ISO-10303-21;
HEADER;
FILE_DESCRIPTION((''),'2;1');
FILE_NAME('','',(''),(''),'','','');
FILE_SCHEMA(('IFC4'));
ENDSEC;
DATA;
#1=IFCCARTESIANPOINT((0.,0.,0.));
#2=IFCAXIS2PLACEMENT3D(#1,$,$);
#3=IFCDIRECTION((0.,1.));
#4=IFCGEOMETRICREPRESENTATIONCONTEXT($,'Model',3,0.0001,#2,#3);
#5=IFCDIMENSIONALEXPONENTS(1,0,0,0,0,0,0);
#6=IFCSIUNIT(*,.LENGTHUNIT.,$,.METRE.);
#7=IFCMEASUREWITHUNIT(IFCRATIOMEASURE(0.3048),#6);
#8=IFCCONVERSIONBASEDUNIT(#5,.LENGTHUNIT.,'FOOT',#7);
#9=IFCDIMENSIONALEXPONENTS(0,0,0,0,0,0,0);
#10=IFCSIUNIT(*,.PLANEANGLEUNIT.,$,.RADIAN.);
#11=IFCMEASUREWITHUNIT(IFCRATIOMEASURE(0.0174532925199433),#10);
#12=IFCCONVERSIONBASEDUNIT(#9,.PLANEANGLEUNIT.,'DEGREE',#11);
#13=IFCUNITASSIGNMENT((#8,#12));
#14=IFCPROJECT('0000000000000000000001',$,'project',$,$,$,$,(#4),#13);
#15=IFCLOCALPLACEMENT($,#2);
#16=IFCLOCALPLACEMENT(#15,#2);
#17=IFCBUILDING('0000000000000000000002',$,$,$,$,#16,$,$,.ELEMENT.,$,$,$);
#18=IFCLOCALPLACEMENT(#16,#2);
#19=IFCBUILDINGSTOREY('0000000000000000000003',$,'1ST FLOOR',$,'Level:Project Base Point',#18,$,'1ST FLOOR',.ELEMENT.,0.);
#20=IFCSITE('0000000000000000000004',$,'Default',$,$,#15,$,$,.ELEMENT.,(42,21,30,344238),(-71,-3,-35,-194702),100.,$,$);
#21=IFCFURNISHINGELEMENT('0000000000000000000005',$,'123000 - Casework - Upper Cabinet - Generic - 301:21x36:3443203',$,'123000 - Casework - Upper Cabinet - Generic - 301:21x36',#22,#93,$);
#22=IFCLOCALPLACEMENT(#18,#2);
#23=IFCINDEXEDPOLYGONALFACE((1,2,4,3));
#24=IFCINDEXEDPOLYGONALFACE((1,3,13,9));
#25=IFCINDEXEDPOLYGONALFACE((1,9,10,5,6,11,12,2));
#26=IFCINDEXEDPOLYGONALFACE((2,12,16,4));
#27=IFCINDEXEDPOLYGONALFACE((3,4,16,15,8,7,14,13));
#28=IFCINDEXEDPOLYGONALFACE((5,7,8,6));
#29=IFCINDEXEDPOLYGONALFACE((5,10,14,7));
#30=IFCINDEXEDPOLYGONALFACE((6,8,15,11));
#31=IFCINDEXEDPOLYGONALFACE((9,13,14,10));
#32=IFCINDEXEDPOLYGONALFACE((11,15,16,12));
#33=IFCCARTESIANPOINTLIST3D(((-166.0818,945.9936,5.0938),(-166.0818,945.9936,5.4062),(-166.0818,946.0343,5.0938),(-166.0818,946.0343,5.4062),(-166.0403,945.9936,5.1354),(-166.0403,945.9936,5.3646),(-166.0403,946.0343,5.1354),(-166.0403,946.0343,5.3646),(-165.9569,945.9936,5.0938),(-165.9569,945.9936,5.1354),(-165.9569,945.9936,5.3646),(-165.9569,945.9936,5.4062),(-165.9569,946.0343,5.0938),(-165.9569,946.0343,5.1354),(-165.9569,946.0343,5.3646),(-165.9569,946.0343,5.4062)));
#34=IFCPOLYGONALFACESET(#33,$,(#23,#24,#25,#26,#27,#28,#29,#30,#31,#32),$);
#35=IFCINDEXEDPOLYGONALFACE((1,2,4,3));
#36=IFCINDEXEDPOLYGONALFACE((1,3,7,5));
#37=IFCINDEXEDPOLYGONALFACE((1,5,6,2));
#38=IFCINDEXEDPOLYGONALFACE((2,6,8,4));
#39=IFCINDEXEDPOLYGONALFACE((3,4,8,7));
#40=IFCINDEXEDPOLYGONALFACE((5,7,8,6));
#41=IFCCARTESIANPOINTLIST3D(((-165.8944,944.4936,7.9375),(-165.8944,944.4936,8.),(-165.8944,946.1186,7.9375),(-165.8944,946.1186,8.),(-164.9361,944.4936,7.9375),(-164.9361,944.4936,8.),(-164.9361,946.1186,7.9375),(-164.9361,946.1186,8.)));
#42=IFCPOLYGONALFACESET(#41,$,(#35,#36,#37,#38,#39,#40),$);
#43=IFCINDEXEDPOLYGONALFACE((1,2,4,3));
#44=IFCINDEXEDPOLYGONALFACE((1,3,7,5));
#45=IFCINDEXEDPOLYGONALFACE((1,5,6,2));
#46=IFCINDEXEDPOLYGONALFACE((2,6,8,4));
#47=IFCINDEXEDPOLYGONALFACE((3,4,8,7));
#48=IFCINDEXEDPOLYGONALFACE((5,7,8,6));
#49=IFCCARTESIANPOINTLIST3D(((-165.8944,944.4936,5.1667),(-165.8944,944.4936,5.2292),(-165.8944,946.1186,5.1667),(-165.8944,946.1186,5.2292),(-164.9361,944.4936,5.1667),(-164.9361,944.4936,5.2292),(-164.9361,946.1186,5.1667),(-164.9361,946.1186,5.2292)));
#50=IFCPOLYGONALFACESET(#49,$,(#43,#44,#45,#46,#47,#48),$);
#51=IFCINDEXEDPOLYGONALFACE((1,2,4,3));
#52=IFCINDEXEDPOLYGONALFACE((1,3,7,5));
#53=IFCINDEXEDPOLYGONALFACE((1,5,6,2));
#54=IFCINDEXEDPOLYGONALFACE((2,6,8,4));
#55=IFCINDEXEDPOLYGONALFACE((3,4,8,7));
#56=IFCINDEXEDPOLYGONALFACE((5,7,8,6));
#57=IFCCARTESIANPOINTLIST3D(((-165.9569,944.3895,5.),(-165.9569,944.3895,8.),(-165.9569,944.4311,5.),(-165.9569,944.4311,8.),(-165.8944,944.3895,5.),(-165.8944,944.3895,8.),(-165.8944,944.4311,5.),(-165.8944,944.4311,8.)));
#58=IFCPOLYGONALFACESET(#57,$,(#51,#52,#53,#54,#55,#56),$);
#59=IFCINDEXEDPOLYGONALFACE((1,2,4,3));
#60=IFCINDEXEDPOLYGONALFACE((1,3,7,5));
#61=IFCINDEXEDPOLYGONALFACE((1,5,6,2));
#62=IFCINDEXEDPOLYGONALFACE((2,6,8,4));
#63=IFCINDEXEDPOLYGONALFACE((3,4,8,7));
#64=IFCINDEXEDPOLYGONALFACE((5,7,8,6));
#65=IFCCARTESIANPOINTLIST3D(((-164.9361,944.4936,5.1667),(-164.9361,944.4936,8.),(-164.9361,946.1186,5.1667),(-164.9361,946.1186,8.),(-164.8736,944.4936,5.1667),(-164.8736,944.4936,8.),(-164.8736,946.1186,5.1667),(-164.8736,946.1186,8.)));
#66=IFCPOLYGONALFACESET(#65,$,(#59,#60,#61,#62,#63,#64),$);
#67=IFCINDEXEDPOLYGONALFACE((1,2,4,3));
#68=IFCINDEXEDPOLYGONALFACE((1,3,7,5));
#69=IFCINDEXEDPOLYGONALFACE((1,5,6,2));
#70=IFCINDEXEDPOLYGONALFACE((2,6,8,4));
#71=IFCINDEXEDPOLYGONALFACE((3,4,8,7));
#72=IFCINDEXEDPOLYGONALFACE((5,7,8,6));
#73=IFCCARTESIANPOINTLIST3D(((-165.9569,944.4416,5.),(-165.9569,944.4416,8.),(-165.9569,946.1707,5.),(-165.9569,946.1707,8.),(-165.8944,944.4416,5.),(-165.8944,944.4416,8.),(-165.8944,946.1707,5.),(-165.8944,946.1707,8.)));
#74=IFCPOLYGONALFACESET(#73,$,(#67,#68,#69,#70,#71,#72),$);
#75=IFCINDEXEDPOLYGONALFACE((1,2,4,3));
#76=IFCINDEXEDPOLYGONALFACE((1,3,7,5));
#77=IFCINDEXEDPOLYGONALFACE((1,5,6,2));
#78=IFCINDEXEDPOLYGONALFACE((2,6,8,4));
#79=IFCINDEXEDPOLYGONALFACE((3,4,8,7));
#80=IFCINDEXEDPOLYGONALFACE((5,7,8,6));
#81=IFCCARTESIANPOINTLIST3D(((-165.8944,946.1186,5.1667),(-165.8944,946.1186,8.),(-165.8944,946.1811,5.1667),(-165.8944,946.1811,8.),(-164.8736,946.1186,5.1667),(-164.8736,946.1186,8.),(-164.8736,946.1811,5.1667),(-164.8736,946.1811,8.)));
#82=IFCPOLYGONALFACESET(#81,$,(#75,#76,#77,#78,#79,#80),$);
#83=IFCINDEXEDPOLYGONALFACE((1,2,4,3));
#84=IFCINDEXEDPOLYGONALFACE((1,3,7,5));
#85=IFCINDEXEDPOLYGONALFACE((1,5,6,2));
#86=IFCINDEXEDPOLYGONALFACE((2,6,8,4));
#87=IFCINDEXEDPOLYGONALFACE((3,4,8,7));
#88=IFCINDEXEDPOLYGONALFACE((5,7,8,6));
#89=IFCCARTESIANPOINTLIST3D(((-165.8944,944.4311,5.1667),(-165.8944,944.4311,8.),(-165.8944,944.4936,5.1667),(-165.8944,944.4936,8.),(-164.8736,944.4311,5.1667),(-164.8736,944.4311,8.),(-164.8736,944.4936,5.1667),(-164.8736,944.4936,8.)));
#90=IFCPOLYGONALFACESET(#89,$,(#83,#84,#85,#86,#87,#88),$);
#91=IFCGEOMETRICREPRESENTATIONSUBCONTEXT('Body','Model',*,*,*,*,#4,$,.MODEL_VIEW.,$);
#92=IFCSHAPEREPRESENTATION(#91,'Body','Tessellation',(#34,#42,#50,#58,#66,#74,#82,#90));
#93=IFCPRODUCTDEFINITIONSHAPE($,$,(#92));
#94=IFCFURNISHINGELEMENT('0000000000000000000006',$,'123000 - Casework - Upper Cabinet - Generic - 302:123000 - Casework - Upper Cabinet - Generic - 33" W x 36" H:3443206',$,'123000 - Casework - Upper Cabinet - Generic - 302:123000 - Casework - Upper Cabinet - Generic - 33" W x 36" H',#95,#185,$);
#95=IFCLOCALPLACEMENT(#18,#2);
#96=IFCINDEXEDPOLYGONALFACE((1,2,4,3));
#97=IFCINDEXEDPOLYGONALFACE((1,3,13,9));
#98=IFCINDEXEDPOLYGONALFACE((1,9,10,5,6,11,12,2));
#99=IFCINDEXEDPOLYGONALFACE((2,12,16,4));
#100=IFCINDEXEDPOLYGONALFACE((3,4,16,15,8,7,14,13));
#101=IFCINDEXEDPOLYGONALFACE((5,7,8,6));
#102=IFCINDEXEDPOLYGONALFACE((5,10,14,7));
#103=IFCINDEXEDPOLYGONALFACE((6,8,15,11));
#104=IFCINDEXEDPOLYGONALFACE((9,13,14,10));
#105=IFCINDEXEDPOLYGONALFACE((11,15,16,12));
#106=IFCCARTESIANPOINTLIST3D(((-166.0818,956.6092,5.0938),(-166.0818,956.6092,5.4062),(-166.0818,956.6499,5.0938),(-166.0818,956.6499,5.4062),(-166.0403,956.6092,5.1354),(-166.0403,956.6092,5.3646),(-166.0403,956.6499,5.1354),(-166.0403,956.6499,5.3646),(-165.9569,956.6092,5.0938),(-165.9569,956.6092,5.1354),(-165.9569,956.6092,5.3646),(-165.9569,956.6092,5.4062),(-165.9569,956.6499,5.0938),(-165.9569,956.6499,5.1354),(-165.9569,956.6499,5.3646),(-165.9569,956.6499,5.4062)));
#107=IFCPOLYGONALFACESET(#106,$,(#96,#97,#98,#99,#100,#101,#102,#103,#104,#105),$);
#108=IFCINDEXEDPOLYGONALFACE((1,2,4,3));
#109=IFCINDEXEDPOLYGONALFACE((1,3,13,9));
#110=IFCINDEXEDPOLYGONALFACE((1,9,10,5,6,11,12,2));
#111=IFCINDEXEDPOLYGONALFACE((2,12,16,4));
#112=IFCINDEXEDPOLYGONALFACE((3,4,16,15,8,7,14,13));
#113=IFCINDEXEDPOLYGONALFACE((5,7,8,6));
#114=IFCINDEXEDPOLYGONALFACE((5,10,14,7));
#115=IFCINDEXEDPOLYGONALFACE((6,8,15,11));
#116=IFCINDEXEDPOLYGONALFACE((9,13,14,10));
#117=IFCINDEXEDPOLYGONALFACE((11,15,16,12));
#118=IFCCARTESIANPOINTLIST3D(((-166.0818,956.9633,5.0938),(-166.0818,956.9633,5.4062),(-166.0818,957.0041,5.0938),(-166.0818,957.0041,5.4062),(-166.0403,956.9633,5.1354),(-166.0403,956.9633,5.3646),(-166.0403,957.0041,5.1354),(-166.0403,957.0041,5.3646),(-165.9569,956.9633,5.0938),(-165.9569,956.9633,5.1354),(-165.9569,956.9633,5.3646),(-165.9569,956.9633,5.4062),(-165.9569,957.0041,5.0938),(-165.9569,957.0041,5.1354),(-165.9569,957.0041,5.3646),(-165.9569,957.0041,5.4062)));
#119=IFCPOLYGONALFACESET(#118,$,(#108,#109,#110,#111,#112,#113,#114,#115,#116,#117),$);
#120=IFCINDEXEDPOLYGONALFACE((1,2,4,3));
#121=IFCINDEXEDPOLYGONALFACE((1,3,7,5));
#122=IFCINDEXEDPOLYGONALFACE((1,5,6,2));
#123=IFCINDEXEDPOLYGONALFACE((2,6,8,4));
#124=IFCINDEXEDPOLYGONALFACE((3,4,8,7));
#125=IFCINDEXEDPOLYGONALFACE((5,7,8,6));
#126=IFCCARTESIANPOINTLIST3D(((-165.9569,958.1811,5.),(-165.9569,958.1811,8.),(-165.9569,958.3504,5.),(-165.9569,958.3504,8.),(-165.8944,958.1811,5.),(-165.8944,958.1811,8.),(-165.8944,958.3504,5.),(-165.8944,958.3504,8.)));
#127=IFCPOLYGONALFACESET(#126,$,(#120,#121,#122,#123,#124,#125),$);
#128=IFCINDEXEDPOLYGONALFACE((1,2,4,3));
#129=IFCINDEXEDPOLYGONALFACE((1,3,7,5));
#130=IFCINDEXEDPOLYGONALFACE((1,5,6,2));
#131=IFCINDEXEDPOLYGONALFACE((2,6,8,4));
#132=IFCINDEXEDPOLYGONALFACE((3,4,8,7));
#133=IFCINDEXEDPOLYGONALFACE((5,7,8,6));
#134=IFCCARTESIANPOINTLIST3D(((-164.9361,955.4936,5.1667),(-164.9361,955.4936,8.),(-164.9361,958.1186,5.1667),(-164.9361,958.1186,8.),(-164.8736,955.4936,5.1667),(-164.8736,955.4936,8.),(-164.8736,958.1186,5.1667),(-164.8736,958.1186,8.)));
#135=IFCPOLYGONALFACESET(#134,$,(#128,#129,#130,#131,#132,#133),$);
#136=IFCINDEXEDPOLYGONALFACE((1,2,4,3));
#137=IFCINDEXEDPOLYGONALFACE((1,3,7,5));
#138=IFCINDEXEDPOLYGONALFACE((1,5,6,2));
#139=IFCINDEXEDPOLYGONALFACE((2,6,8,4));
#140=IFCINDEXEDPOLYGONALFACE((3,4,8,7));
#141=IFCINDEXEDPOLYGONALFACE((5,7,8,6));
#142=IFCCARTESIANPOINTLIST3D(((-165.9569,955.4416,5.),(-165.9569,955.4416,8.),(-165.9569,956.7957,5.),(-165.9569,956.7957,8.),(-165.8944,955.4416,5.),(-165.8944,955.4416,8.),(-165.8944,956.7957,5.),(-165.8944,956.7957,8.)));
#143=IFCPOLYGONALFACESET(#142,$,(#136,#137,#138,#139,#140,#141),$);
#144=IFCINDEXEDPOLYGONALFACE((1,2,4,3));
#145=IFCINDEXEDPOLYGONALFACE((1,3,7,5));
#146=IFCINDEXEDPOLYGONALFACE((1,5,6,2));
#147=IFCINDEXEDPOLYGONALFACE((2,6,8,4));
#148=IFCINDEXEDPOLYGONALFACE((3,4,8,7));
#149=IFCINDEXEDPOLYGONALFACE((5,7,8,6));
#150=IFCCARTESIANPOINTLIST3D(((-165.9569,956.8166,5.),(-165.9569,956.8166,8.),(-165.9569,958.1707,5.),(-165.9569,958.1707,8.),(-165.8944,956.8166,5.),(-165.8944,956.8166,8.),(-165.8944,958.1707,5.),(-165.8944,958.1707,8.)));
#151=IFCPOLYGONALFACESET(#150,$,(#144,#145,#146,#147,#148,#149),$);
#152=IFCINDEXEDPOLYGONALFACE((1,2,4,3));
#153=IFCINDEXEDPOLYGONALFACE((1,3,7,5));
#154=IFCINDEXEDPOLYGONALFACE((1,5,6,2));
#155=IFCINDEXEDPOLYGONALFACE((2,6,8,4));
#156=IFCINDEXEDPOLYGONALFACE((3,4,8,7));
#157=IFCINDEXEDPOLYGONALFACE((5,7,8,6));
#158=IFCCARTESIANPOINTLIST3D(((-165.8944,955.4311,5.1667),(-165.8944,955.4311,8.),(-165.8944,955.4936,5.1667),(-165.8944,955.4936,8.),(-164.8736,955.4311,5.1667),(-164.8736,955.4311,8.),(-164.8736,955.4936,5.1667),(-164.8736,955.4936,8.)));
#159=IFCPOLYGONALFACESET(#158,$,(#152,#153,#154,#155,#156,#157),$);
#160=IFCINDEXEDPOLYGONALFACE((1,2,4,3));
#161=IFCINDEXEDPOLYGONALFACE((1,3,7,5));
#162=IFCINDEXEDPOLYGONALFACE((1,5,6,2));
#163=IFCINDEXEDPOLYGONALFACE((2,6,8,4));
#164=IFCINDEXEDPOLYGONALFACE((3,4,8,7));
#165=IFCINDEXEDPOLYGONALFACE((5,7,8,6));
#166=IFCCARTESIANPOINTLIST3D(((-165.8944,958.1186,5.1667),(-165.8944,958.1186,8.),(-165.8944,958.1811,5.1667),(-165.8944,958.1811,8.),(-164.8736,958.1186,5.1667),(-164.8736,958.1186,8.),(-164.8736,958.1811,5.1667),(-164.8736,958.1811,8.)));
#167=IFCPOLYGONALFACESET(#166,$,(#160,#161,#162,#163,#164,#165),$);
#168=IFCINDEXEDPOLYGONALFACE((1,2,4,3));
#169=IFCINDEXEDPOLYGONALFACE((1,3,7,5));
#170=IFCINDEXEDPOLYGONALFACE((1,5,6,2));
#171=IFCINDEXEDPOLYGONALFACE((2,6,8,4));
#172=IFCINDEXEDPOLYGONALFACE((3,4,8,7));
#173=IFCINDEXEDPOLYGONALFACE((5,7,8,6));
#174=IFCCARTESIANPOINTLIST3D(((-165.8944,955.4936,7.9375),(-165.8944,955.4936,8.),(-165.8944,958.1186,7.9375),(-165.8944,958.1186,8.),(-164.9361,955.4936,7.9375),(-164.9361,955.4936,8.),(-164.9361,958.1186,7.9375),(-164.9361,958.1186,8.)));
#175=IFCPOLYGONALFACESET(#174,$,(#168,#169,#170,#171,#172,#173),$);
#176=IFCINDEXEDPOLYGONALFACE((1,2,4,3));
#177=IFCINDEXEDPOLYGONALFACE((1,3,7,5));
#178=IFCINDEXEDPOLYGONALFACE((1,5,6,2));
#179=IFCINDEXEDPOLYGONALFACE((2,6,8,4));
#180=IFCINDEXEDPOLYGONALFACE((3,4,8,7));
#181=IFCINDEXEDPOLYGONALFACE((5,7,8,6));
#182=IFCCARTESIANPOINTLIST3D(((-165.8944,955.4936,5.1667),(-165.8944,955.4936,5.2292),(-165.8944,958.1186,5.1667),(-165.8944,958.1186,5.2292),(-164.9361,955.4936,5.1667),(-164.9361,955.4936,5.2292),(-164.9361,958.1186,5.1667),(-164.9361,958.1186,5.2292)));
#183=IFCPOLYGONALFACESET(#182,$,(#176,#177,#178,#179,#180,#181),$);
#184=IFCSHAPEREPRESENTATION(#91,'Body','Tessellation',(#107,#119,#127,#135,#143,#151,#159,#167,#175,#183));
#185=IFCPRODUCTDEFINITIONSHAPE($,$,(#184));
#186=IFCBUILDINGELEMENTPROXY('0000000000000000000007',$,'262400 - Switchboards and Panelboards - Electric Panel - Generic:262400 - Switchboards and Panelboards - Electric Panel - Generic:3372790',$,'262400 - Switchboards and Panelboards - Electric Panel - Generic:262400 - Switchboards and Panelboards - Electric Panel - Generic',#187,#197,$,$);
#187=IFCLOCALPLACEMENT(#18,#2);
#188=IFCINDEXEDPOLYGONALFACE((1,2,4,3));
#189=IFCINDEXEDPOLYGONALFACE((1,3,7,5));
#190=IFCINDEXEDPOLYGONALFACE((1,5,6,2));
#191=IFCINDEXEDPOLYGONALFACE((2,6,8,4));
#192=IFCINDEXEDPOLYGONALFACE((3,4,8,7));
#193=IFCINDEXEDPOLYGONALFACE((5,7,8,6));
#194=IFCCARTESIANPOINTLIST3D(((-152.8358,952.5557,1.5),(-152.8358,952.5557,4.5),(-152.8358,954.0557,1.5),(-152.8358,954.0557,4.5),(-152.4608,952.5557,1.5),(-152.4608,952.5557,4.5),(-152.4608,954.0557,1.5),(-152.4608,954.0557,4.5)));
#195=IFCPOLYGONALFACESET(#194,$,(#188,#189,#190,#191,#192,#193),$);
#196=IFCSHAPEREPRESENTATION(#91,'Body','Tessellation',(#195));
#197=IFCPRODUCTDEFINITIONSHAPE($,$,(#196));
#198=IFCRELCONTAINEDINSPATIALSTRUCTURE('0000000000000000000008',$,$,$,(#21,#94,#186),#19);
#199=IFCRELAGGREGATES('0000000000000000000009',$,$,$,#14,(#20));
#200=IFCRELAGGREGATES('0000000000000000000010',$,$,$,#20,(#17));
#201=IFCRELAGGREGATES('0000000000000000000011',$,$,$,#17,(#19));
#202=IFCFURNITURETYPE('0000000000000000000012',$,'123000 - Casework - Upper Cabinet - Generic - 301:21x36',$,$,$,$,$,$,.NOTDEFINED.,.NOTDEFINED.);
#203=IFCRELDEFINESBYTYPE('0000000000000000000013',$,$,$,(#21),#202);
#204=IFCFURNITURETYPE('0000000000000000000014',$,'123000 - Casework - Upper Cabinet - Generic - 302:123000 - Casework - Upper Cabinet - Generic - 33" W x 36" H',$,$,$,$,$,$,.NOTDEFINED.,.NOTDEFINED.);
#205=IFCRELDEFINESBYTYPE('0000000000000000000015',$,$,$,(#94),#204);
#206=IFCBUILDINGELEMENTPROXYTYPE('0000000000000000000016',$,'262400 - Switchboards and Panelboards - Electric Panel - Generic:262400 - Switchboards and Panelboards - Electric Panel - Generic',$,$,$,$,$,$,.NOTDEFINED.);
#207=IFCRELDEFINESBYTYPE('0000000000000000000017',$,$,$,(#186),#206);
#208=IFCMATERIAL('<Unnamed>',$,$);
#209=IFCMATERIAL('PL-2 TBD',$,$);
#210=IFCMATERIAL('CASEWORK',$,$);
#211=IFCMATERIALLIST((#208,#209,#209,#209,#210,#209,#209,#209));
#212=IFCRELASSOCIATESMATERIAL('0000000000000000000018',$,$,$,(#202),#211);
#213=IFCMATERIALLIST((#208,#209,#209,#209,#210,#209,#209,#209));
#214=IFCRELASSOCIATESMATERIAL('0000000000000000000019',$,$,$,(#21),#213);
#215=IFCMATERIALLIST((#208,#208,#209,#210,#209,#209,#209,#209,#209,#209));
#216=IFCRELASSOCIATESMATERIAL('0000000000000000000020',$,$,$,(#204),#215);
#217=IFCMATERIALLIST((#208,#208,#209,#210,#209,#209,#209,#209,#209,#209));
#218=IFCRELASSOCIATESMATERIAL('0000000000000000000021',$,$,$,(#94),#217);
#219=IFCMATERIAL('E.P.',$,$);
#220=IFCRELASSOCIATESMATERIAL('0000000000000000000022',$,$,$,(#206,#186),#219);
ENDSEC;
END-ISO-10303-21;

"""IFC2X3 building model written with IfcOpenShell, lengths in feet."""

from ifc_helpers import new_model, entity, si_unit, converted_unit, direction, frame, frame_2d, origin, origin_2d_with_axis, place, context, subcontext, project, spatial, polyline, rectangle, outline, extrude, source, transform, mapped, material, material_list, type_object, type_shapes, element, save


model = new_model("IFC2X3")

# Units and contexts
model_context = context("Model", 3, precision=0.0001, world=origin(), true_north=direction((0.0, 1.0)))
body_context = subcontext(model_context, "Body", "Model", "MODEL_VIEW")
ifc_project = project(units=[converted_unit("LENGTHUNIT", "FOOT", entity("IfcRatioMeasure", 0.3048), si_unit("LENGTHUNIT", "METRE"), dimensions=[1, 0, 0, 0, 0, 0, 0]), converted_unit("PLANEANGLEUNIT", "DEGREE", entity("IfcRatioMeasure", 0.0174532925199433), si_unit("PLANEANGLEUNIT", "RADIAN"), dimensions=[0, 0, 0, 0, 0, 0, 0])], contexts=[model_context])

# Site, building, storey
site_placement = place(None, origin())
site = spatial("IfcSite", under=ifc_project, at=site_placement, Name="Default", CompositionType="ELEMENT", RefLatitude=(42, 21, 30, 344238), RefLongitude=(-71, -3, -35, -194702), RefElevation=100.0)
building_placement = place(site_placement, origin())
building = spatial("IfcBuilding", under=site, at=building_placement, CompositionType="ELEMENT")
storey_placement = place(building_placement, origin())
storey = spatial("IfcBuildingStorey", under=building, at=storey_placement, Name="1ST FLOOR", ObjectType="Level:Project Base Point", LongName="1ST FLOOR", CompositionType="ELEMENT", Elevation=0.0)

# Shared definitions
ifc_material_1 = material(Name="CASEWORK")

# Furnishing elements
ifc_material_2 = material(Name="<Unnamed>")
ifc_material_3 = material(Name="PL-2 TBD")
ifc_material_list_1 = material_list([ifc_material_2, ifc_material_3, ifc_material_3, ifc_material_3, ifc_material_1, ifc_material_3, ifc_material_3, ifc_material_3])
ifc_material_list_2 = material_list([ifc_material_2, ifc_material_3, ifc_material_3, ifc_material_3, ifc_material_1, ifc_material_3, ifc_material_3, ifc_material_3])
furniture_type_1 = type_object("IfcFurnitureType", Name="123000 - Casework - Upper Cabinet - Generic - 301:21x36", material=ifc_material_list_2)
shared_shape_1 = source(origin(), body_context, "Body", "SweptSolid", [
    extrude(outline(polyline([(0.1146, -0.0521), (0.1562, -0.0521), (0.1562, 0.0729), (-0.1562, 0.0729), (-0.1562, -0.0521), (-0.1146, -0.0521), (-0.1146, 0.0313), (0.1146, 0.0313), (0.1146, -0.0521)])), frame((0.1468, 0.0729, 0.25), z_axis=(1.0, 0.0, 0.0), x_axis=(0.0, 0.0, 1.0)), (0.0, 0.0, 1.0), 0.0407),
    extrude(rectangle(XDim=1.625, YDim=0.9583, at=frame_2d((0.0, 0.0), x_axis=(1.0, 0.0))), frame((0.875, 0.6666, 2.9375), z_axis=(0.0, 0.0, 1.0), x_axis=(-1.0, 0.0, 0.0)), (0.0, 0.0, 1.0), 0.0625),
    extrude(rectangle(XDim=1.625, YDim=0.9583, at=frame_2d((0.0, 0.0), x_axis=(1.0, 0.0))), frame((0.875, 0.6666, 0.1667), z_axis=(0.0, 0.0, 1.0), x_axis=(-1.0, 0.0, 0.0)), (0.0, 0.0, 1.0), 0.0625),
    extrude(rectangle(XDim=0.0625, YDim=0.0417, at=frame_2d((0.0, 0.0), x_axis=(1.0, 0.0))), frame((1.7708, 0.1562, 0.0), z_axis=(0.0, 0.0, 1.0), x_axis=(0.0, -1.0, 0.0)), (0.0, 0.0, 1.0), 3.0),
    extrude(rectangle(XDim=0.0625, YDim=1.625, at=origin_2d_with_axis()), frame((0.875, 1.177, 0.1667), z_axis=(0.0, 0.0, 1.0), x_axis=(0.0, 1.0, 0.0)), (0.0, 0.0, 1.0), 2.8333),
    extrude(rectangle(XDim=0.0625, YDim=1.7292, at=frame_2d((0.0, 0.0), x_axis=(1.0, 0.0))), frame((0.875, 0.1562, 0.0), z_axis=(0.0, 0.0, 1.0), x_axis=(0.0, -1.0, 0.0)), (0.0, 0.0, 1.0), 3.0),
    extrude(rectangle(XDim=0.0625, YDim=1.0208, at=origin_2d_with_axis()), frame((0.0312, 0.6979, 0.1667), z_axis=(0.0, 0.0, 1.0), x_axis=(-1.0, 0.0, 0.0)), (0.0, 0.0, 1.0), 2.8333),
    extrude(rectangle(XDim=0.0625, YDim=1.0208, at=origin_2d_with_axis()), frame((1.7188, 0.6979, 0.1667), z_axis=(0.0, 0.0, 1.0), x_axis=(-1.0, 0.0, 0.0)), (0.0, 0.0, 1.0), 2.8333),
])
type_shapes(furniture_type_1, [shared_shape_1])
furnishing_1_placement = place(storey_placement, frame((-166.0818, 946.1811, 5.0), z_axis=(0.0, 0.0, 1.0), x_axis=(0.0, -1.0, 0.0)))
element("IfcFurnishingElement", 1, at=furnishing_1_placement, inside=storey, type_object=furniture_type_1, material=ifc_material_list_1, Name="123000 - Casework - Upper Cabinet - Generic - 301:21x36:3443203", ObjectType="123000 - Casework - Upper Cabinet - Generic - 301:21x36", context=body_context, shape_type="MappedRepresentation", body=[
    mapped(shared_shape_1, transform((0.0, 0.0, 0.0), scale=1.0)),
])
ifc_material_list_3 = material_list([ifc_material_2, ifc_material_2, ifc_material_3, ifc_material_1, ifc_material_3, ifc_material_3, ifc_material_3, ifc_material_3, ifc_material_3, ifc_material_3])
ifc_material_list_4 = material_list([ifc_material_2, ifc_material_2, ifc_material_3, ifc_material_1, ifc_material_3, ifc_material_3, ifc_material_3, ifc_material_3, ifc_material_3, ifc_material_3])
furniture_type_2 = type_object("IfcFurnitureType", Name="123000 - Casework - Upper Cabinet - Generic - 302:123000 - Casework - Upper Cabinet - Generic - 33\" W x 36\" H", material=ifc_material_list_4)
shared_shape_2 = source(origin(), body_context, "Body", "SweptSolid", [
    extrude(outline(polyline([(-0.0521, -0.1146), (-0.0521, -0.1562), (0.0729, -0.1562), (0.0729, 0.1562), (-0.0521, 0.1562), (-0.0521, 0.1146), (0.0313, 0.1146), (0.0313, -0.1146), (-0.0521, -0.1146)])), frame((1.178, 1.1354, 0.25), z_axis=(-1.0, 0.0, 0.0), x_axis=(0.0, 1.0, 0.0)), (0.0, 0.0, -1.0), 0.0407),
    extrude(outline(polyline([(-0.0521, -0.1146), (-0.0521, -0.1562), (0.0729, -0.1562), (0.0729, 0.1562), (-0.0521, 0.1562), (-0.0521, 0.1146), (0.0313, 0.1146), (0.0313, -0.1146), (-0.0521, -0.1146)])), frame((1.5322, 1.1354, 0.25), z_axis=(-1.0, 0.0, 0.0), x_axis=(0.0, 1.0, 0.0)), (0.0, 0.0, -1.0), 0.0407),
    extrude(rectangle(XDim=0.1693, YDim=0.0625, at=frame_2d((0.0, 0.0), x_axis=(1.0, 0.0))), frame((2.8346, 1.0521, 0.0)), (0.0, 0.0, 1.0), 3.0),
    extrude(rectangle(XDim=2.625, YDim=0.0625, at=frame_2d((0.0, 0.0), x_axis=(1.0, 0.0))), frame((1.375, 0.0313, 0.1667), z_axis=(0.0, 0.0, 1.0), x_axis=(-1.0, 0.0, 0.0)), (0.0, 0.0, 1.0), 2.8333),
    extrude(rectangle(XDim=1.3542, YDim=0.0625, at=origin_2d_with_axis()), frame((0.6875, 1.0521, 0.0)), (0.0, 0.0, 1.0), 3.0),
    extrude(rectangle(XDim=1.3542, YDim=0.0625, at=origin_2d_with_axis()), frame((2.0625, 1.0521, 0.0)), (0.0, 0.0, 1.0), 3.0),
    extrude(rectangle(XDim=1.0208, YDim=0.0625, at=origin_2d_with_axis()), frame((0.0312, 0.5104, 0.1667), z_axis=(0.0, 0.0, 1.0), x_axis=(0.0, 1.0, 0.0)), (0.0, 0.0, 1.0), 2.8333),
    extrude(rectangle(XDim=1.0208, YDim=0.0625, at=frame_2d((0.0, 0.0), x_axis=(1.0, 0.0))), frame((2.7188, 0.5104, 0.1667), z_axis=(0.0, 0.0, 1.0), x_axis=(0.0, 1.0, 0.0)), (0.0, 0.0, 1.0), 2.8333),
    extrude(rectangle(XDim=0.9583, YDim=2.625, at=frame_2d((0.0, 0.0), x_axis=(1.0, 0.0))), frame((1.375, 0.5417, 2.9375), z_axis=(0.0, 0.0, 1.0), x_axis=(0.0, 1.0, 0.0)), (0.0, 0.0, 1.0), 0.0625),
    extrude(rectangle(XDim=0.9583, YDim=2.625, at=frame_2d((0.0, 0.0), x_axis=(1.0, 0.0))), frame((1.375, 0.5417, 0.1667), z_axis=(0.0, 0.0, 1.0), x_axis=(0.0, 1.0, 0.0)), (0.0, 0.0, 1.0), 0.0625),
])
type_shapes(furniture_type_2, [shared_shape_2])
furnishing_2_placement = place(storey_placement, frame((-164.8736, 955.4311, 5.0), z_axis=(0.0, 0.0, 1.0), x_axis=(0.0, 1.0, 0.0)))
element("IfcFurnishingElement", 2, at=furnishing_2_placement, inside=storey, type_object=furniture_type_2, material=ifc_material_list_3, Name="123000 - Casework - Upper Cabinet - Generic - 302:123000 - Casework - Upper Cabinet - Generic - 33\" W x 36\" H:3443206", ObjectType="123000 - Casework - Upper Cabinet - Generic - 302:123000 - Casework - Upper Cabinet - Generic - 33\" W x 36\" H", context=body_context, shape_type="MappedRepresentation", body=[
    mapped(shared_shape_2, transform((0.0, 0.0, 0.0), scale=1.0)),
])

# Building element proxy
ifc_material_4 = material(Name="E.P.")
building_element_proxy_type_1 = type_object("IfcBuildingElementProxyType", Name="262400 - Switchboards and Panelboards - Electric Panel - Generic:262400 - Switchboards and Panelboards - Electric Panel - Generic", PredefinedType="NOTDEFINED", material=ifc_material_4)
shared_shape_3 = source(origin(), body_context, "Body", "SweptSolid", [
    extrude(rectangle(XDim=0.375, YDim=1.5, at=origin_2d_with_axis()), frame((0.75, 0.1875, 0.0), z_axis=(0.0, 0.0, 1.0), x_axis=(0.0, 1.0, 0.0)), (0.0, 0.0, 1.0), 3.0),
])
type_shapes(building_element_proxy_type_1, [shared_shape_3])
proxy_1_placement = place(storey_placement, frame((-152.4608, 952.5557, 1.5), z_axis=(0.0, 0.0, 1.0), x_axis=(0.0, 1.0, 0.0)))
element("IfcBuildingElementProxy", 3, at=proxy_1_placement, inside=storey, type_object=building_element_proxy_type_1, material=ifc_material_4, Name="262400 - Switchboards and Panelboards - Electric Panel - Generic:262400 - Switchboards and Panelboards - Electric Panel - Generic:3372790", ObjectType="262400 - Switchboards and Panelboards - Electric Panel - Generic:262400 - Switchboards and Panelboards - Electric Panel - Generic", context=body_context, shape_type="MappedRepresentation", body=[
    mapped(shared_shape_3, transform((0.0, 0.0, 0.0), scale=1.0)),
])

save(model, "model.ifc")
